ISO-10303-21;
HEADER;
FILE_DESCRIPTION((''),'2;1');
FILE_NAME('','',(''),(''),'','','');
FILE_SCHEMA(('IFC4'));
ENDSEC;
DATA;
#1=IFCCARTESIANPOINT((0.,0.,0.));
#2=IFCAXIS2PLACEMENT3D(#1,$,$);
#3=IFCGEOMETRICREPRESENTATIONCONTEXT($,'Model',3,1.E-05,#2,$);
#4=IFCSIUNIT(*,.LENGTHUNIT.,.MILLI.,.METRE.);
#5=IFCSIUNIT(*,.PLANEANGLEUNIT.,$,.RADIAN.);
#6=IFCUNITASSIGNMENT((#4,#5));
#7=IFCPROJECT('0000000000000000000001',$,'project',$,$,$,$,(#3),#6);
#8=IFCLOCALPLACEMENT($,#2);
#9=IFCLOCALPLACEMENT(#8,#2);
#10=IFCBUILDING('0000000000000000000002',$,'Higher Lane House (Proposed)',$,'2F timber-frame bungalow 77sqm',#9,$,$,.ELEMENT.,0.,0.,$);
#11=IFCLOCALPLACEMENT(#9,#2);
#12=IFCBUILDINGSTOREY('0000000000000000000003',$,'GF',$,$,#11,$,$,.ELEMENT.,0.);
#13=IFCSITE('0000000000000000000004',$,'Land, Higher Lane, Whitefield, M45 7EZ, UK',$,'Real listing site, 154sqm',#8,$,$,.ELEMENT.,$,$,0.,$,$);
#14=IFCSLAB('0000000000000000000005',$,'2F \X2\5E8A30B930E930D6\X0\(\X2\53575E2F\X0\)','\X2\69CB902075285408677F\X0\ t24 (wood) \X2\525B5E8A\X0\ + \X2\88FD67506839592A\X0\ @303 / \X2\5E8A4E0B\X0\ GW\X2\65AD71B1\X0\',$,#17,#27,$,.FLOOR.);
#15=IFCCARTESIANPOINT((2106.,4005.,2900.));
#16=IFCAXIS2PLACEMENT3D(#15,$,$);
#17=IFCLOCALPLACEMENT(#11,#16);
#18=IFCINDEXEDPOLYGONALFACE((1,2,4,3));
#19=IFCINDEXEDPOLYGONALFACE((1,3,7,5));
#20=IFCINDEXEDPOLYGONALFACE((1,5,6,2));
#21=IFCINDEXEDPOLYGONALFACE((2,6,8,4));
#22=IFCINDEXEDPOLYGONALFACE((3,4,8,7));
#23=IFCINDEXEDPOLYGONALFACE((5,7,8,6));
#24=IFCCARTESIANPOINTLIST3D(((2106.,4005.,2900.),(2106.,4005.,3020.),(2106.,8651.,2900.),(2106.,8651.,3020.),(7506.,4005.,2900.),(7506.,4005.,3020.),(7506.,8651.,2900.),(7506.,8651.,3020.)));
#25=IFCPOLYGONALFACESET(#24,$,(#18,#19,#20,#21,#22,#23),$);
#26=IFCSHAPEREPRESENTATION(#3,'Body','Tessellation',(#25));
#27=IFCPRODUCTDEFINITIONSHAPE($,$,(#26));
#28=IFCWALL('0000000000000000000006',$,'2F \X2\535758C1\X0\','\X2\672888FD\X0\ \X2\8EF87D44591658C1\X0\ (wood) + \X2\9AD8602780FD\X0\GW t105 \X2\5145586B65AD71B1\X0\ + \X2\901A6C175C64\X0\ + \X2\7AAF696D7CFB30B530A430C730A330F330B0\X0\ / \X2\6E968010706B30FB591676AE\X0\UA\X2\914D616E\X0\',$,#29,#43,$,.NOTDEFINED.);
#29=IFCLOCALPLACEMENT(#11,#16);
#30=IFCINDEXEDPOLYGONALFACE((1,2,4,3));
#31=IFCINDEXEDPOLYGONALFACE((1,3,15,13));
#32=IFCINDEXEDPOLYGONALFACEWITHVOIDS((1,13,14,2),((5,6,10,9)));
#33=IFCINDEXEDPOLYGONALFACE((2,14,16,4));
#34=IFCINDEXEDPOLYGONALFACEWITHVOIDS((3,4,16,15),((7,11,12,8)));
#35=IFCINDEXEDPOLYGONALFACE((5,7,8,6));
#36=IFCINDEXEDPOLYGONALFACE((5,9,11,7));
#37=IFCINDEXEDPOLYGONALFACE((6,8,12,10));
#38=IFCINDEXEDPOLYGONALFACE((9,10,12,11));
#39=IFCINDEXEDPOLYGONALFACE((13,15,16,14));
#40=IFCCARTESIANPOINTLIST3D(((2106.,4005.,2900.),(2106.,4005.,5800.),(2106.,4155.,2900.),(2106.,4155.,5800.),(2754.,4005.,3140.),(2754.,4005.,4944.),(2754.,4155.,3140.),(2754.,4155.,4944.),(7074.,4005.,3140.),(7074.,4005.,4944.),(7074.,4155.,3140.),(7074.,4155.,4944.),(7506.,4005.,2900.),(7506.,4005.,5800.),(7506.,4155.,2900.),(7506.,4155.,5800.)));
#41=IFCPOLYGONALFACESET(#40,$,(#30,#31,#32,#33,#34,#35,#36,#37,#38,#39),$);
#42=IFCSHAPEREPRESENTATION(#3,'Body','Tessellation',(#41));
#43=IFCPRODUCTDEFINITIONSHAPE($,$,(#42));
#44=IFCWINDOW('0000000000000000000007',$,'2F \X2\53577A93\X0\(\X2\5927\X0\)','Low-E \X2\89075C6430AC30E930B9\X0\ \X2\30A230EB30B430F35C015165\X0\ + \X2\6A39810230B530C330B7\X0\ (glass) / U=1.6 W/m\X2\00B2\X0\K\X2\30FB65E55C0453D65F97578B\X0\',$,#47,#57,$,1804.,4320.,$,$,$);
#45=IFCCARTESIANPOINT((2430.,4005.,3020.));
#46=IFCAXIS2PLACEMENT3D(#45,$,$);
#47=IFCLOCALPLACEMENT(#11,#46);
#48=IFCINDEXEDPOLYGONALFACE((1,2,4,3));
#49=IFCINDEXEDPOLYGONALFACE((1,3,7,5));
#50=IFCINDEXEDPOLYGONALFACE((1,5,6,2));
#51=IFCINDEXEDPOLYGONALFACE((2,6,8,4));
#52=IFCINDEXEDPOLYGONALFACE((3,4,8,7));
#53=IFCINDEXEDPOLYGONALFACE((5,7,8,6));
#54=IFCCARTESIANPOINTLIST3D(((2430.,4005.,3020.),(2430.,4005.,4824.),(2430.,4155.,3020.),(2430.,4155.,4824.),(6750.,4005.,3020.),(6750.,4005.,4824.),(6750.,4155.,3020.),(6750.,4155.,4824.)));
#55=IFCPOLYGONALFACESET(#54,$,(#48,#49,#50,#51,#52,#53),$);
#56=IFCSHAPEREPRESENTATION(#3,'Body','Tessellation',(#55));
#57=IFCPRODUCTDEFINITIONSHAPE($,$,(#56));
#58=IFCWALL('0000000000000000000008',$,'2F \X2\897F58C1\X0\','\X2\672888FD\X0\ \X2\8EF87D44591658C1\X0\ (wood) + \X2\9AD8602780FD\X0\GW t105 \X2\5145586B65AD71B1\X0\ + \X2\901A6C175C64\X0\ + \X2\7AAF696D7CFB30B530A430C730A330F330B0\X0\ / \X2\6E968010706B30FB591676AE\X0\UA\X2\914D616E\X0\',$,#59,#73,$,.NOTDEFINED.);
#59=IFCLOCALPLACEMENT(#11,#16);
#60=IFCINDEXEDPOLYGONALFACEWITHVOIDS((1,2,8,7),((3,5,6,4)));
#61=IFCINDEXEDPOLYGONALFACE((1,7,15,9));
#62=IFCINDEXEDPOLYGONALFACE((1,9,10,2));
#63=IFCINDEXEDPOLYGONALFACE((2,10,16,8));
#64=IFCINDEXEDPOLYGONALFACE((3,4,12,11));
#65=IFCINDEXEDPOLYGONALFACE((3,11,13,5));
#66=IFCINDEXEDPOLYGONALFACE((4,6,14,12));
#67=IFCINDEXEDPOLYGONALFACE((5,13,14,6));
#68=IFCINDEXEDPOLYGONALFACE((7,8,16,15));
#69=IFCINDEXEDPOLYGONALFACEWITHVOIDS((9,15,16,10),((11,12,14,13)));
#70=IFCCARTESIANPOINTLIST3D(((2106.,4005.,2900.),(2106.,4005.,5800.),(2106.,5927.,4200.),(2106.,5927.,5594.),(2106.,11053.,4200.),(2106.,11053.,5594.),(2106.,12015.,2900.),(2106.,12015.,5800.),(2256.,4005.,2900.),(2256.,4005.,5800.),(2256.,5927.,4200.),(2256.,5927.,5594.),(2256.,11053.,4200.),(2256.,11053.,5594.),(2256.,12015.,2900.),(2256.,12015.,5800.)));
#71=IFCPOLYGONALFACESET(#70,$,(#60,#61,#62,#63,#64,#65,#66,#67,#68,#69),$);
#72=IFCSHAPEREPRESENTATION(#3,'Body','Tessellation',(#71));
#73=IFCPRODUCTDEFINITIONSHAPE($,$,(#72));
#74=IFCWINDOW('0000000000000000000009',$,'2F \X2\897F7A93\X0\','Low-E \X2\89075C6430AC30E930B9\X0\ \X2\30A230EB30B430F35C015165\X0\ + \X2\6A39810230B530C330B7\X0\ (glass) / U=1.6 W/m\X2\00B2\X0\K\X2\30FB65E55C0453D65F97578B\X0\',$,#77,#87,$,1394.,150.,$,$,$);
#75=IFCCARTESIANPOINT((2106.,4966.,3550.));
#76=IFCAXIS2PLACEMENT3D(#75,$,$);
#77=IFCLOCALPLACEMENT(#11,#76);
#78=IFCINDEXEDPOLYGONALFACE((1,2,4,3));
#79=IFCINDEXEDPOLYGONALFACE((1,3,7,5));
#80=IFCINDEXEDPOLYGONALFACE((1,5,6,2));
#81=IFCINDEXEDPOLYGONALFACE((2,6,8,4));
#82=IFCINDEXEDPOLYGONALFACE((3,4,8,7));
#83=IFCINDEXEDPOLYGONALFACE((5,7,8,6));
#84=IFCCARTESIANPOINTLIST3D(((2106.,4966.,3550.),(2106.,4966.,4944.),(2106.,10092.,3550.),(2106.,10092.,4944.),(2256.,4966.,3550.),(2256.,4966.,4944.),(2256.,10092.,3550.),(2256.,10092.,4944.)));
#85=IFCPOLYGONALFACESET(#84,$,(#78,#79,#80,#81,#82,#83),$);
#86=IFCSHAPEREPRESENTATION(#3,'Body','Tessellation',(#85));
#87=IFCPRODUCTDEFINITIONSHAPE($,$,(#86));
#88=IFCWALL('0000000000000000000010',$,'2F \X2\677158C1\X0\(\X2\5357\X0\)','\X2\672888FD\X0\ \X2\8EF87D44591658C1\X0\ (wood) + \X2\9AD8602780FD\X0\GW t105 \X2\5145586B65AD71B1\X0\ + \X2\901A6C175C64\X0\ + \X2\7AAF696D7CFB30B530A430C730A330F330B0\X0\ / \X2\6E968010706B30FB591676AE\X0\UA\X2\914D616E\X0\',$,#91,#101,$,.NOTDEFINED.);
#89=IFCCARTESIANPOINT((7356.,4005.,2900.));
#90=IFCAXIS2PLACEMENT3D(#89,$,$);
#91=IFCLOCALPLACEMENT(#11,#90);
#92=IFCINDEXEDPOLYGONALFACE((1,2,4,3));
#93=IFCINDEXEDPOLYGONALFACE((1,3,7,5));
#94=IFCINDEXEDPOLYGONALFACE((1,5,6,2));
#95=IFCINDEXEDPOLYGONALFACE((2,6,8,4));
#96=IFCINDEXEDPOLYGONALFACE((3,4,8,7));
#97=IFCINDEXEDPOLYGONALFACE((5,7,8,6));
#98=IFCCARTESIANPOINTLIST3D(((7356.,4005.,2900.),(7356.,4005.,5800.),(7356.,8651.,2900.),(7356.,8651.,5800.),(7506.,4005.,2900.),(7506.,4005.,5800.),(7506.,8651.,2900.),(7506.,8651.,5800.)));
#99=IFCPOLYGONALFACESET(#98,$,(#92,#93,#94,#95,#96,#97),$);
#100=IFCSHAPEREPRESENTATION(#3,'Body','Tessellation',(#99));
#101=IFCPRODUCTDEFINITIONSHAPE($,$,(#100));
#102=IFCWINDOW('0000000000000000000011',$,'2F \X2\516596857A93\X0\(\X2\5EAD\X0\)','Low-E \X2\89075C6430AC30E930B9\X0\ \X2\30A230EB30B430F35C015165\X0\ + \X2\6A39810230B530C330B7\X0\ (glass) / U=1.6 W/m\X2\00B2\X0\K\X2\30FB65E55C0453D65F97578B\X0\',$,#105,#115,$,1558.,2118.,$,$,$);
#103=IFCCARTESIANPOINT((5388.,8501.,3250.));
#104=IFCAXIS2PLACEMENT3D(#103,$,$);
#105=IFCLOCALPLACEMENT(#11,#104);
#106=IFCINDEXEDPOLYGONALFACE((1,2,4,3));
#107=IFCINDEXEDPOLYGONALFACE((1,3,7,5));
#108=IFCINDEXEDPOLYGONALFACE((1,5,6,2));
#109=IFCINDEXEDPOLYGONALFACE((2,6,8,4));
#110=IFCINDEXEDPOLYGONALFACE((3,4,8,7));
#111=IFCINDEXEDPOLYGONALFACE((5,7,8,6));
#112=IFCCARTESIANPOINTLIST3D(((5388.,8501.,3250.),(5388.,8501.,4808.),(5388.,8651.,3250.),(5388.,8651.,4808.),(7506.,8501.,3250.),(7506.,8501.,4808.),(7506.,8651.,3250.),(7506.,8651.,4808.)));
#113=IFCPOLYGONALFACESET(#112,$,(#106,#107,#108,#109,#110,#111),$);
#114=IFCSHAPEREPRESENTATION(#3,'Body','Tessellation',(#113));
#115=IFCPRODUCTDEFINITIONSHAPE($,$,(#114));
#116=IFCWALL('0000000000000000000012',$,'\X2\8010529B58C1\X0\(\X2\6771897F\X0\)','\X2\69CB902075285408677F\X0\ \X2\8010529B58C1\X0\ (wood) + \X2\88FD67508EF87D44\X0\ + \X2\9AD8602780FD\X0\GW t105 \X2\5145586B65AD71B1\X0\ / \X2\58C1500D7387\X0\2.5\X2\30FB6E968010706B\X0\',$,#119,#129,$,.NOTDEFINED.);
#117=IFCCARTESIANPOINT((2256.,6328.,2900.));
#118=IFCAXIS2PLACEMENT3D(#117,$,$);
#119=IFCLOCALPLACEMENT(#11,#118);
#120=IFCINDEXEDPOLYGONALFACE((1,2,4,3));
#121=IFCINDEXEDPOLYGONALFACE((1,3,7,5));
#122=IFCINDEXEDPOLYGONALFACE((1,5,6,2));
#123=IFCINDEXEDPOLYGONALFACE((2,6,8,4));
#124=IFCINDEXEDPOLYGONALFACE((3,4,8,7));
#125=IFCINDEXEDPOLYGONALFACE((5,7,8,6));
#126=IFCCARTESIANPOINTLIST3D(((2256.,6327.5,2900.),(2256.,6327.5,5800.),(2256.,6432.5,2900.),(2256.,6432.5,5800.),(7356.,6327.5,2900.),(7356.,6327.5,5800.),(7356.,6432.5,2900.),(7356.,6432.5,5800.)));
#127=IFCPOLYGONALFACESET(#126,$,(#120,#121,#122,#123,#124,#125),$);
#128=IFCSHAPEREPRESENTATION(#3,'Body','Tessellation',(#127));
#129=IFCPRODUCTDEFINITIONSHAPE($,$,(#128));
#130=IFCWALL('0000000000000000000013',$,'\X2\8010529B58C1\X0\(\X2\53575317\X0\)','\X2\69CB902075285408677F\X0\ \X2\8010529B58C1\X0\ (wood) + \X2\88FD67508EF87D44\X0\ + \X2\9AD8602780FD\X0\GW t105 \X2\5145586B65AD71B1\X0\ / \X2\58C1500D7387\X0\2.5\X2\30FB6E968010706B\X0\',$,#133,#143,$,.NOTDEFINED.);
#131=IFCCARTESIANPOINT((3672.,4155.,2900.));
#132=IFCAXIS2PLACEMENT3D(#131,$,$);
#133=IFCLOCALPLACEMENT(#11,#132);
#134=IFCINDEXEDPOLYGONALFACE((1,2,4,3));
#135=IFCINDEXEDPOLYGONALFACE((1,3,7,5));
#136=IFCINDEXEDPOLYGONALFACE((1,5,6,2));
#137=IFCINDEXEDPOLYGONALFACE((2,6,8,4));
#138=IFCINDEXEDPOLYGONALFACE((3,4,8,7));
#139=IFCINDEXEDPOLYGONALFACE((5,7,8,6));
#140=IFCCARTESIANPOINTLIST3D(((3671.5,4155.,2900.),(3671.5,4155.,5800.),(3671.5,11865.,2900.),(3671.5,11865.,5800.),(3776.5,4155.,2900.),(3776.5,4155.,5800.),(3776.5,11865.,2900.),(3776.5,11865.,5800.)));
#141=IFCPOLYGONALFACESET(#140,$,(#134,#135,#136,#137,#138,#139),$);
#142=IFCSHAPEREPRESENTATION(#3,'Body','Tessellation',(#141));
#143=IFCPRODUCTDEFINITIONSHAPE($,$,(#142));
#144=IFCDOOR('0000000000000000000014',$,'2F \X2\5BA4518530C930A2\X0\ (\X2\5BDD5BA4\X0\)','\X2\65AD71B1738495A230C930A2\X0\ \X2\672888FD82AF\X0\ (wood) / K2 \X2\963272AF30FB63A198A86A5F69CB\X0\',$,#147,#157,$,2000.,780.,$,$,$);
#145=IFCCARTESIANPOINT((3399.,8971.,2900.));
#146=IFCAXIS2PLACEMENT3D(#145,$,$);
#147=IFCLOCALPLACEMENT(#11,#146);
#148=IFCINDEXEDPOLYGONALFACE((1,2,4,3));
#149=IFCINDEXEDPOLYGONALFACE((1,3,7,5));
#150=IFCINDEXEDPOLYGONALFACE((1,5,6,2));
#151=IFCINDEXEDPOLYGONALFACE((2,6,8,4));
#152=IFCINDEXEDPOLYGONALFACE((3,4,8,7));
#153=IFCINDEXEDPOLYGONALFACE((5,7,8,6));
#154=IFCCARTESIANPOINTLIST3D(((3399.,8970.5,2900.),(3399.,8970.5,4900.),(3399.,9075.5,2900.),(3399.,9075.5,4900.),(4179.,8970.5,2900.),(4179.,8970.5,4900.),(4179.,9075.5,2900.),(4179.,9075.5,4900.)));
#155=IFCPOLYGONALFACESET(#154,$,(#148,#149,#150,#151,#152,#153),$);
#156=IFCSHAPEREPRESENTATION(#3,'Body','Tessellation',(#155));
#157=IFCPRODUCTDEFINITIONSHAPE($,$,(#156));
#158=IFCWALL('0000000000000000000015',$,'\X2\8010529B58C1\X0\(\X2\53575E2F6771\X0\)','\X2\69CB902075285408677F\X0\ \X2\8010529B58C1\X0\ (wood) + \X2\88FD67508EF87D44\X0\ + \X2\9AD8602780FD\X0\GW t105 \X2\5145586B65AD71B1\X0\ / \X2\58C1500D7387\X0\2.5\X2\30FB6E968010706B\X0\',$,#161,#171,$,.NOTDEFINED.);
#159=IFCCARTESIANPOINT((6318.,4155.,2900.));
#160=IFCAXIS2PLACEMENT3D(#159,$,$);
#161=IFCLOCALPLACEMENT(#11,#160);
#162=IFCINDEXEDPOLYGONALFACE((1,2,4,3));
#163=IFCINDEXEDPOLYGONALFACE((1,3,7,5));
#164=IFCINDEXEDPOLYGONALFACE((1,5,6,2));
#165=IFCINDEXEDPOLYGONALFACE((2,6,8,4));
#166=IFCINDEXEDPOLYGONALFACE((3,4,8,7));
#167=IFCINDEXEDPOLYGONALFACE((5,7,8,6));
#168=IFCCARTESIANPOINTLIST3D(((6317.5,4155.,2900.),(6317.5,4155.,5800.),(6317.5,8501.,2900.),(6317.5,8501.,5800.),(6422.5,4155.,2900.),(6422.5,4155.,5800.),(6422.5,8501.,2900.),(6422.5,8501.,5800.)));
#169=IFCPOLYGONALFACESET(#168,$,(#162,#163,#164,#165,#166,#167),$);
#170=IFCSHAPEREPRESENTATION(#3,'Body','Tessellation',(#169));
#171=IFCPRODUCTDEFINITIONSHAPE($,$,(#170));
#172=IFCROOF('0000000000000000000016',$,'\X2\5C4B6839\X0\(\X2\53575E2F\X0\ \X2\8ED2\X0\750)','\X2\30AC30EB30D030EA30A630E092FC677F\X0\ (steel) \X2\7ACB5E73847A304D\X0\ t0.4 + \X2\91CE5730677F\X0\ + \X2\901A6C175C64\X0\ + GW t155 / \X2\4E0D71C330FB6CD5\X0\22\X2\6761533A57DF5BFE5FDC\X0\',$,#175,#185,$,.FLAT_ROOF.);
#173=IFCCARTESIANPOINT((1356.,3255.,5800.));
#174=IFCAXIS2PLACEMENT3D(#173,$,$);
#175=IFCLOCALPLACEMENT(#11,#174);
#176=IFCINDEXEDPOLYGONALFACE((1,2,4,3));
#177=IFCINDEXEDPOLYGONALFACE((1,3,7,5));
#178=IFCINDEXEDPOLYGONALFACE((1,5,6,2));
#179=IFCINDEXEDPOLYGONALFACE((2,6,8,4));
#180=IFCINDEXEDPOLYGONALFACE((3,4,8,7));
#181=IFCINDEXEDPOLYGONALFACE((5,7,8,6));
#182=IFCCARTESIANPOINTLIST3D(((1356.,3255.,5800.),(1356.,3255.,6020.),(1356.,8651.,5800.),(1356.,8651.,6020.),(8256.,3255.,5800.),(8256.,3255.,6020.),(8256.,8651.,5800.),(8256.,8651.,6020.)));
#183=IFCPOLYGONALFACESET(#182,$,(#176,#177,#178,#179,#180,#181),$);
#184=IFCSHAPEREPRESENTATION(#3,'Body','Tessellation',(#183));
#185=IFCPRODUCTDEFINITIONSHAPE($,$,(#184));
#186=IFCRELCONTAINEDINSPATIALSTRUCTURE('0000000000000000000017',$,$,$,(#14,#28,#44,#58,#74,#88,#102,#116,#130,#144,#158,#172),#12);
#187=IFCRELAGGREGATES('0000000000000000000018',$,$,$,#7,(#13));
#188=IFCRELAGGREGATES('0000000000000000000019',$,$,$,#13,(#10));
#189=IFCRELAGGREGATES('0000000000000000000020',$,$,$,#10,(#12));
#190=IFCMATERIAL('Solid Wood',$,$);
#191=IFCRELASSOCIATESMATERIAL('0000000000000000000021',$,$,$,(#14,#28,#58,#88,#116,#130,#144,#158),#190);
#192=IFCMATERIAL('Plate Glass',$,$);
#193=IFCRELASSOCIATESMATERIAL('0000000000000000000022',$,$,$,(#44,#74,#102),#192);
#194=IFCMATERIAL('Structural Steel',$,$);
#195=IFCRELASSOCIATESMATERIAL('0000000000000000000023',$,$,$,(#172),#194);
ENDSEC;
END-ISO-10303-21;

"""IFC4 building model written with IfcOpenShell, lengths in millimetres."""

from ifc_helpers import new_model, si_unit, frame, frame_2d, origin, place, context, project, spatial, rectangle, extrude, material, element, fill, save


model = new_model("IFC4")

# Units and contexts
model_context = context("Model", 3, precision=1e-05, world=origin())
ifc_project = project(units=[si_unit("LENGTHUNIT", "METRE", prefix="MILLI"), si_unit("PLANEANGLEUNIT", "RADIAN")], contexts=[model_context])

# Site, building, storey
site_placement = place(None, origin())
site = spatial("IfcSite", under=ifc_project, at=site_placement, Name="Land, Higher Lane, Whitefield, M45 7EZ, UK", ObjectType="Real listing site, 154sqm", CompositionType="ELEMENT", RefElevation=0.0)
building_placement = place(site_placement, origin())
building = spatial("IfcBuilding", under=site, at=building_placement, Name="Higher Lane House (Proposed)", ObjectType="2F timber-frame bungalow 77sqm", CompositionType="ELEMENT", ElevationOfRefHeight=0.0, ElevationOfTerrain=0.0)
storey_placement = place(building_placement, origin())
storey = spatial("IfcBuildingStorey", under=building, at=storey_placement, Name="GF", CompositionType="ELEMENT", Elevation=0.0)

# Slab
ifc_material_1 = material(Name="Solid Wood")
slab_placement = place(storey_placement, frame((2106.0, 4005.0, 2900.0)))
element("IfcSlab", 1, at=slab_placement, inside=storey, material=ifc_material_1, Name="2F 床スラブ(南帯)", Description="構造用合板 t24 (wood) 剛床 + 製材根太 @303 / 床下 GW断熱", PredefinedType="FLOOR", context=model_context, shape_type="SweptSolid", body=[
    extrude(rectangle(XDim=5400.0, YDim=4646.0, at=frame_2d((2700.0, 2323.0))), frame((2106.0, 4005.0, 2900.0)), (0.0, 0.0, 1.0), 120.0),
])

# Walls, openings, windows
wall_1_placement = place(storey_placement, frame((2106.0, 4005.0, 2900.0)))
wall_1 = element("IfcWall", 2, at=wall_1_placement, inside=storey, material=ifc_material_1, Name="2F 南壁", Description="木製 軸組外壁 (wood) + 高性能GW t105 充填断熱 + 通気層 + 窯業系サイディング / 準耐火・外皮UA配慮", PredefinedType="NOTDEFINED", context=model_context, shape_type="SweptSolid", body=[
    extrude(rectangle(XDim=5400.0, YDim=150.0, at=frame_2d((2700.0, 75.0))), frame((2106.0, 4005.0, 2900.0)), (0.0, 0.0, 1.0), 2900.0),
])
opening_1_placement = place(storey_placement, frame((2430.0, 4005.0, 3020.0)))
opening_1 = element("IfcOpeningElement", 3, at=opening_1_placement, cuts=wall_1, PredefinedType="NOTDEFINED", context=model_context, shape_type="SweptSolid", body=[
    extrude(rectangle(XDim=4320.0, YDim=150.0, at=frame_2d((2160.0, 75.0))), frame((2430.0, 4005.0, 3020.0)), (0.0, 0.0, 1.0), 1804.0),
])
ifc_material_2 = material(Name="Plate Glass")
window_1_placement = place(storey_placement, frame((2430.0, 4005.0, 3020.0)))
window_1 = element("IfcWindow", 4, at=window_1_placement, inside=storey, material=ifc_material_2, Name="2F 南窓(大)", Description="Low-E 複層ガラス アルゴン封入 + 樹脂サッシ (glass) / U=1.6 W/m²K・日射取得型", OverallHeight=1804.0, OverallWidth=4320.0, context=model_context, shape_type="SweptSolid", body=[
    extrude(rectangle(XDim=4320.0, YDim=150.0, at=frame_2d((2160.0, 75.0))), frame((2430.0, 4005.0, 3020.0)), (0.0, 0.0, 1.0), 1804.0),
])
fill(opening_1, window_1)
wall_2_placement = place(storey_placement, frame((2106.0, 4005.0, 2900.0)))
wall_2 = element("IfcWall", 5, at=wall_2_placement, inside=storey, material=ifc_material_1, Name="2F 西壁", Description="木製 軸組外壁 (wood) + 高性能GW t105 充填断熱 + 通気層 + 窯業系サイディング / 準耐火・外皮UA配慮", PredefinedType="NOTDEFINED", context=model_context, shape_type="SweptSolid", body=[
    extrude(rectangle(XDim=150.0, YDim=8010.0, at=frame_2d((75.0, 4005.0))), frame((2106.0, 4005.0, 2900.0)), (0.0, 0.0, 1.0), 2900.0),
])
opening_2_placement = place(storey_placement, frame((2106.0, 4966.0, 3550.0)))
opening_2 = element("IfcOpeningElement", 6, at=opening_2_placement, cuts=wall_2, PredefinedType="NOTDEFINED", context=model_context, shape_type="SweptSolid", body=[
    extrude(rectangle(XDim=150.0, YDim=5126.0, at=frame_2d((75.0, 2563.0))), frame((2106.0, 4966.0, 3550.0)), (0.0, 0.0, 1.0), 1394.0),
])
window_2_placement = place(storey_placement, frame((2106.0, 4966.0, 3550.0)))
window_2 = element("IfcWindow", 7, at=window_2_placement, inside=storey, material=ifc_material_2, Name="2F 西窓", Description="Low-E 複層ガラス アルゴン封入 + 樹脂サッシ (glass) / U=1.6 W/m²K・日射取得型", OverallHeight=1394.0, OverallWidth=150.0, context=model_context, shape_type="SweptSolid", body=[
    extrude(rectangle(XDim=150.0, YDim=5126.0, at=frame_2d((75.0, 2563.0))), frame((2106.0, 4966.0, 3550.0)), (0.0, 0.0, 1.0), 1394.0),
])
fill(opening_2, window_2)
wall_3_placement = place(storey_placement, frame((7356.0, 4005.0, 2900.0)))
wall_3 = element("IfcWall", 8, at=wall_3_placement, inside=storey, material=ifc_material_1, Name="2F 東壁(南)", Description="木製 軸組外壁 (wood) + 高性能GW t105 充填断熱 + 通気層 + 窯業系サイディング / 準耐火・外皮UA配慮", PredefinedType="NOTDEFINED", context=model_context, shape_type="SweptSolid", body=[
    extrude(rectangle(XDim=150.0, YDim=4646.0, at=frame_2d((75.0, 2323.0))), frame((7356.0, 4005.0, 2900.0)), (0.0, 0.0, 1.0), 2900.0),
])
opening_3_placement = place(storey_placement, frame((5388.0, 8501.0, 3250.0)))
opening_3 = element("IfcOpeningElement", 9, at=opening_3_placement, cuts=wall_3, PredefinedType="NOTDEFINED", context=model_context, shape_type="SweptSolid", body=[
    extrude(rectangle(XDim=2118.0, YDim=150.0, at=frame_2d((1059.0, 75.0))), frame((5388.0, 8501.0, 3250.0)), (0.0, 0.0, 1.0), 1558.0),
])
window_3_placement = place(storey_placement, frame((5388.0, 8501.0, 3250.0)))
window_3 = element("IfcWindow", 10, at=window_3_placement, inside=storey, material=ifc_material_2, Name="2F 入隅窓(庭)", Description="Low-E 複層ガラス アルゴン封入 + 樹脂サッシ (glass) / U=1.6 W/m²K・日射取得型", OverallHeight=1558.0, OverallWidth=2118.0, context=model_context, shape_type="SweptSolid", body=[
    extrude(rectangle(XDim=2118.0, YDim=150.0, at=frame_2d((1059.0, 75.0))), frame((5388.0, 8501.0, 3250.0)), (0.0, 0.0, 1.0), 1558.0),
])
fill(opening_3, window_3)

# Wall
wall_4_placement = place(storey_placement, frame((2256.0, 6328.0, 2900.0)))
element("IfcWall", 11, at=wall_4_placement, inside=storey, material=ifc_material_1, Name="耐力壁(東西)", Description="構造用合板 耐力壁 (wood) + 製材軸組 + 高性能GW t105 充填断熱 / 壁倍率2.5・準耐火", PredefinedType="NOTDEFINED", context=model_context, shape_type="SweptSolid", body=[
    extrude(rectangle(XDim=5100.0, YDim=105.0, at=frame_2d((2550.0, 52.0))), frame((2256.0, 6328.0, 2900.0)), (0.0, 0.0, 1.0), 2900.0),
])

# Wall, opening, door
wall_5_placement = place(storey_placement, frame((3672.0, 4155.0, 2900.0)))
wall_5 = element("IfcWall", 12, at=wall_5_placement, inside=storey, material=ifc_material_1, Name="耐力壁(南北)", Description="構造用合板 耐力壁 (wood) + 製材軸組 + 高性能GW t105 充填断熱 / 壁倍率2.5・準耐火", PredefinedType="NOTDEFINED", context=model_context, shape_type="SweptSolid", body=[
    extrude(rectangle(XDim=105.0, YDim=7710.0, at=frame_2d((52.0, 3855.0))), frame((3672.0, 4155.0, 2900.0)), (0.0, 0.0, 1.0), 2900.0),
])
opening_4_placement = place(storey_placement, frame((3399.0, 8971.0, 2900.0)))
opening_4 = element("IfcOpeningElement", 13, at=opening_4_placement, cuts=wall_5, PredefinedType="NOTDEFINED", context=model_context, shape_type="SweptSolid", body=[
    extrude(rectangle(XDim=780.0, YDim=105.0, at=frame_2d((390.0, 52.0))), frame((3399.0, 8971.0, 2900.0)), (0.0, 0.0, 1.0), 2000.0),
])
door_placement = place(storey_placement, frame((3399.0, 8971.0, 2900.0)))
door = element("IfcDoor", 14, at=door_placement, inside=storey, material=ifc_material_1, Name="2F 室内ドア (寝室)", Description="断熱玄関ドア 木製芯 (wood) / K2 防犯・採風機構", OverallHeight=2000.0, OverallWidth=780.0, context=model_context, shape_type="SweptSolid", body=[
    extrude(rectangle(XDim=780.0, YDim=105.0, at=frame_2d((390.0, 52.0))), frame((3399.0, 8971.0, 2900.0)), (0.0, 0.0, 1.0), 2000.0),
])
fill(opening_4, door)

# Wall
wall_6_placement = place(storey_placement, frame((6318.0, 4155.0, 2900.0)))
element("IfcWall", 15, at=wall_6_placement, inside=storey, material=ifc_material_1, Name="耐力壁(南帯東)", Description="構造用合板 耐力壁 (wood) + 製材軸組 + 高性能GW t105 充填断熱 / 壁倍率2.5・準耐火", PredefinedType="NOTDEFINED", context=model_context, shape_type="SweptSolid", body=[
    extrude(rectangle(XDim=105.0, YDim=4346.0, at=frame_2d((52.0, 2173.0))), frame((6318.0, 4155.0, 2900.0)), (0.0, 0.0, 1.0), 2900.0),
])

# Roof
ifc_material_3 = material(Name="Structural Steel")
for number, where, name in (
    (16, (1356.0, 3255.0, 5800.0), "屋根(南帯 軒750)"),
):
    element("IfcRoof", number, at=place(storey_placement, frame(where)), inside=storey, material=ifc_material_3, Name=name, Description="ガルバリウム鋼板 (steel) 立平葺き t0.4 + 野地板 + 通気層 + GW t155 / 不燃・法22条区域対応", PredefinedType="FLAT_ROOF", context=model_context, shape_type="SweptSolid", body=[
        extrude(rectangle(XDim=6900.0, YDim=5396.0, at=frame_2d((3450.0, 2698.0))), frame((1356.0, 3255.0, 5800.0)), (0.0, 0.0, 1.0), 220.0),
    ])

save(model, "model.ifc")
